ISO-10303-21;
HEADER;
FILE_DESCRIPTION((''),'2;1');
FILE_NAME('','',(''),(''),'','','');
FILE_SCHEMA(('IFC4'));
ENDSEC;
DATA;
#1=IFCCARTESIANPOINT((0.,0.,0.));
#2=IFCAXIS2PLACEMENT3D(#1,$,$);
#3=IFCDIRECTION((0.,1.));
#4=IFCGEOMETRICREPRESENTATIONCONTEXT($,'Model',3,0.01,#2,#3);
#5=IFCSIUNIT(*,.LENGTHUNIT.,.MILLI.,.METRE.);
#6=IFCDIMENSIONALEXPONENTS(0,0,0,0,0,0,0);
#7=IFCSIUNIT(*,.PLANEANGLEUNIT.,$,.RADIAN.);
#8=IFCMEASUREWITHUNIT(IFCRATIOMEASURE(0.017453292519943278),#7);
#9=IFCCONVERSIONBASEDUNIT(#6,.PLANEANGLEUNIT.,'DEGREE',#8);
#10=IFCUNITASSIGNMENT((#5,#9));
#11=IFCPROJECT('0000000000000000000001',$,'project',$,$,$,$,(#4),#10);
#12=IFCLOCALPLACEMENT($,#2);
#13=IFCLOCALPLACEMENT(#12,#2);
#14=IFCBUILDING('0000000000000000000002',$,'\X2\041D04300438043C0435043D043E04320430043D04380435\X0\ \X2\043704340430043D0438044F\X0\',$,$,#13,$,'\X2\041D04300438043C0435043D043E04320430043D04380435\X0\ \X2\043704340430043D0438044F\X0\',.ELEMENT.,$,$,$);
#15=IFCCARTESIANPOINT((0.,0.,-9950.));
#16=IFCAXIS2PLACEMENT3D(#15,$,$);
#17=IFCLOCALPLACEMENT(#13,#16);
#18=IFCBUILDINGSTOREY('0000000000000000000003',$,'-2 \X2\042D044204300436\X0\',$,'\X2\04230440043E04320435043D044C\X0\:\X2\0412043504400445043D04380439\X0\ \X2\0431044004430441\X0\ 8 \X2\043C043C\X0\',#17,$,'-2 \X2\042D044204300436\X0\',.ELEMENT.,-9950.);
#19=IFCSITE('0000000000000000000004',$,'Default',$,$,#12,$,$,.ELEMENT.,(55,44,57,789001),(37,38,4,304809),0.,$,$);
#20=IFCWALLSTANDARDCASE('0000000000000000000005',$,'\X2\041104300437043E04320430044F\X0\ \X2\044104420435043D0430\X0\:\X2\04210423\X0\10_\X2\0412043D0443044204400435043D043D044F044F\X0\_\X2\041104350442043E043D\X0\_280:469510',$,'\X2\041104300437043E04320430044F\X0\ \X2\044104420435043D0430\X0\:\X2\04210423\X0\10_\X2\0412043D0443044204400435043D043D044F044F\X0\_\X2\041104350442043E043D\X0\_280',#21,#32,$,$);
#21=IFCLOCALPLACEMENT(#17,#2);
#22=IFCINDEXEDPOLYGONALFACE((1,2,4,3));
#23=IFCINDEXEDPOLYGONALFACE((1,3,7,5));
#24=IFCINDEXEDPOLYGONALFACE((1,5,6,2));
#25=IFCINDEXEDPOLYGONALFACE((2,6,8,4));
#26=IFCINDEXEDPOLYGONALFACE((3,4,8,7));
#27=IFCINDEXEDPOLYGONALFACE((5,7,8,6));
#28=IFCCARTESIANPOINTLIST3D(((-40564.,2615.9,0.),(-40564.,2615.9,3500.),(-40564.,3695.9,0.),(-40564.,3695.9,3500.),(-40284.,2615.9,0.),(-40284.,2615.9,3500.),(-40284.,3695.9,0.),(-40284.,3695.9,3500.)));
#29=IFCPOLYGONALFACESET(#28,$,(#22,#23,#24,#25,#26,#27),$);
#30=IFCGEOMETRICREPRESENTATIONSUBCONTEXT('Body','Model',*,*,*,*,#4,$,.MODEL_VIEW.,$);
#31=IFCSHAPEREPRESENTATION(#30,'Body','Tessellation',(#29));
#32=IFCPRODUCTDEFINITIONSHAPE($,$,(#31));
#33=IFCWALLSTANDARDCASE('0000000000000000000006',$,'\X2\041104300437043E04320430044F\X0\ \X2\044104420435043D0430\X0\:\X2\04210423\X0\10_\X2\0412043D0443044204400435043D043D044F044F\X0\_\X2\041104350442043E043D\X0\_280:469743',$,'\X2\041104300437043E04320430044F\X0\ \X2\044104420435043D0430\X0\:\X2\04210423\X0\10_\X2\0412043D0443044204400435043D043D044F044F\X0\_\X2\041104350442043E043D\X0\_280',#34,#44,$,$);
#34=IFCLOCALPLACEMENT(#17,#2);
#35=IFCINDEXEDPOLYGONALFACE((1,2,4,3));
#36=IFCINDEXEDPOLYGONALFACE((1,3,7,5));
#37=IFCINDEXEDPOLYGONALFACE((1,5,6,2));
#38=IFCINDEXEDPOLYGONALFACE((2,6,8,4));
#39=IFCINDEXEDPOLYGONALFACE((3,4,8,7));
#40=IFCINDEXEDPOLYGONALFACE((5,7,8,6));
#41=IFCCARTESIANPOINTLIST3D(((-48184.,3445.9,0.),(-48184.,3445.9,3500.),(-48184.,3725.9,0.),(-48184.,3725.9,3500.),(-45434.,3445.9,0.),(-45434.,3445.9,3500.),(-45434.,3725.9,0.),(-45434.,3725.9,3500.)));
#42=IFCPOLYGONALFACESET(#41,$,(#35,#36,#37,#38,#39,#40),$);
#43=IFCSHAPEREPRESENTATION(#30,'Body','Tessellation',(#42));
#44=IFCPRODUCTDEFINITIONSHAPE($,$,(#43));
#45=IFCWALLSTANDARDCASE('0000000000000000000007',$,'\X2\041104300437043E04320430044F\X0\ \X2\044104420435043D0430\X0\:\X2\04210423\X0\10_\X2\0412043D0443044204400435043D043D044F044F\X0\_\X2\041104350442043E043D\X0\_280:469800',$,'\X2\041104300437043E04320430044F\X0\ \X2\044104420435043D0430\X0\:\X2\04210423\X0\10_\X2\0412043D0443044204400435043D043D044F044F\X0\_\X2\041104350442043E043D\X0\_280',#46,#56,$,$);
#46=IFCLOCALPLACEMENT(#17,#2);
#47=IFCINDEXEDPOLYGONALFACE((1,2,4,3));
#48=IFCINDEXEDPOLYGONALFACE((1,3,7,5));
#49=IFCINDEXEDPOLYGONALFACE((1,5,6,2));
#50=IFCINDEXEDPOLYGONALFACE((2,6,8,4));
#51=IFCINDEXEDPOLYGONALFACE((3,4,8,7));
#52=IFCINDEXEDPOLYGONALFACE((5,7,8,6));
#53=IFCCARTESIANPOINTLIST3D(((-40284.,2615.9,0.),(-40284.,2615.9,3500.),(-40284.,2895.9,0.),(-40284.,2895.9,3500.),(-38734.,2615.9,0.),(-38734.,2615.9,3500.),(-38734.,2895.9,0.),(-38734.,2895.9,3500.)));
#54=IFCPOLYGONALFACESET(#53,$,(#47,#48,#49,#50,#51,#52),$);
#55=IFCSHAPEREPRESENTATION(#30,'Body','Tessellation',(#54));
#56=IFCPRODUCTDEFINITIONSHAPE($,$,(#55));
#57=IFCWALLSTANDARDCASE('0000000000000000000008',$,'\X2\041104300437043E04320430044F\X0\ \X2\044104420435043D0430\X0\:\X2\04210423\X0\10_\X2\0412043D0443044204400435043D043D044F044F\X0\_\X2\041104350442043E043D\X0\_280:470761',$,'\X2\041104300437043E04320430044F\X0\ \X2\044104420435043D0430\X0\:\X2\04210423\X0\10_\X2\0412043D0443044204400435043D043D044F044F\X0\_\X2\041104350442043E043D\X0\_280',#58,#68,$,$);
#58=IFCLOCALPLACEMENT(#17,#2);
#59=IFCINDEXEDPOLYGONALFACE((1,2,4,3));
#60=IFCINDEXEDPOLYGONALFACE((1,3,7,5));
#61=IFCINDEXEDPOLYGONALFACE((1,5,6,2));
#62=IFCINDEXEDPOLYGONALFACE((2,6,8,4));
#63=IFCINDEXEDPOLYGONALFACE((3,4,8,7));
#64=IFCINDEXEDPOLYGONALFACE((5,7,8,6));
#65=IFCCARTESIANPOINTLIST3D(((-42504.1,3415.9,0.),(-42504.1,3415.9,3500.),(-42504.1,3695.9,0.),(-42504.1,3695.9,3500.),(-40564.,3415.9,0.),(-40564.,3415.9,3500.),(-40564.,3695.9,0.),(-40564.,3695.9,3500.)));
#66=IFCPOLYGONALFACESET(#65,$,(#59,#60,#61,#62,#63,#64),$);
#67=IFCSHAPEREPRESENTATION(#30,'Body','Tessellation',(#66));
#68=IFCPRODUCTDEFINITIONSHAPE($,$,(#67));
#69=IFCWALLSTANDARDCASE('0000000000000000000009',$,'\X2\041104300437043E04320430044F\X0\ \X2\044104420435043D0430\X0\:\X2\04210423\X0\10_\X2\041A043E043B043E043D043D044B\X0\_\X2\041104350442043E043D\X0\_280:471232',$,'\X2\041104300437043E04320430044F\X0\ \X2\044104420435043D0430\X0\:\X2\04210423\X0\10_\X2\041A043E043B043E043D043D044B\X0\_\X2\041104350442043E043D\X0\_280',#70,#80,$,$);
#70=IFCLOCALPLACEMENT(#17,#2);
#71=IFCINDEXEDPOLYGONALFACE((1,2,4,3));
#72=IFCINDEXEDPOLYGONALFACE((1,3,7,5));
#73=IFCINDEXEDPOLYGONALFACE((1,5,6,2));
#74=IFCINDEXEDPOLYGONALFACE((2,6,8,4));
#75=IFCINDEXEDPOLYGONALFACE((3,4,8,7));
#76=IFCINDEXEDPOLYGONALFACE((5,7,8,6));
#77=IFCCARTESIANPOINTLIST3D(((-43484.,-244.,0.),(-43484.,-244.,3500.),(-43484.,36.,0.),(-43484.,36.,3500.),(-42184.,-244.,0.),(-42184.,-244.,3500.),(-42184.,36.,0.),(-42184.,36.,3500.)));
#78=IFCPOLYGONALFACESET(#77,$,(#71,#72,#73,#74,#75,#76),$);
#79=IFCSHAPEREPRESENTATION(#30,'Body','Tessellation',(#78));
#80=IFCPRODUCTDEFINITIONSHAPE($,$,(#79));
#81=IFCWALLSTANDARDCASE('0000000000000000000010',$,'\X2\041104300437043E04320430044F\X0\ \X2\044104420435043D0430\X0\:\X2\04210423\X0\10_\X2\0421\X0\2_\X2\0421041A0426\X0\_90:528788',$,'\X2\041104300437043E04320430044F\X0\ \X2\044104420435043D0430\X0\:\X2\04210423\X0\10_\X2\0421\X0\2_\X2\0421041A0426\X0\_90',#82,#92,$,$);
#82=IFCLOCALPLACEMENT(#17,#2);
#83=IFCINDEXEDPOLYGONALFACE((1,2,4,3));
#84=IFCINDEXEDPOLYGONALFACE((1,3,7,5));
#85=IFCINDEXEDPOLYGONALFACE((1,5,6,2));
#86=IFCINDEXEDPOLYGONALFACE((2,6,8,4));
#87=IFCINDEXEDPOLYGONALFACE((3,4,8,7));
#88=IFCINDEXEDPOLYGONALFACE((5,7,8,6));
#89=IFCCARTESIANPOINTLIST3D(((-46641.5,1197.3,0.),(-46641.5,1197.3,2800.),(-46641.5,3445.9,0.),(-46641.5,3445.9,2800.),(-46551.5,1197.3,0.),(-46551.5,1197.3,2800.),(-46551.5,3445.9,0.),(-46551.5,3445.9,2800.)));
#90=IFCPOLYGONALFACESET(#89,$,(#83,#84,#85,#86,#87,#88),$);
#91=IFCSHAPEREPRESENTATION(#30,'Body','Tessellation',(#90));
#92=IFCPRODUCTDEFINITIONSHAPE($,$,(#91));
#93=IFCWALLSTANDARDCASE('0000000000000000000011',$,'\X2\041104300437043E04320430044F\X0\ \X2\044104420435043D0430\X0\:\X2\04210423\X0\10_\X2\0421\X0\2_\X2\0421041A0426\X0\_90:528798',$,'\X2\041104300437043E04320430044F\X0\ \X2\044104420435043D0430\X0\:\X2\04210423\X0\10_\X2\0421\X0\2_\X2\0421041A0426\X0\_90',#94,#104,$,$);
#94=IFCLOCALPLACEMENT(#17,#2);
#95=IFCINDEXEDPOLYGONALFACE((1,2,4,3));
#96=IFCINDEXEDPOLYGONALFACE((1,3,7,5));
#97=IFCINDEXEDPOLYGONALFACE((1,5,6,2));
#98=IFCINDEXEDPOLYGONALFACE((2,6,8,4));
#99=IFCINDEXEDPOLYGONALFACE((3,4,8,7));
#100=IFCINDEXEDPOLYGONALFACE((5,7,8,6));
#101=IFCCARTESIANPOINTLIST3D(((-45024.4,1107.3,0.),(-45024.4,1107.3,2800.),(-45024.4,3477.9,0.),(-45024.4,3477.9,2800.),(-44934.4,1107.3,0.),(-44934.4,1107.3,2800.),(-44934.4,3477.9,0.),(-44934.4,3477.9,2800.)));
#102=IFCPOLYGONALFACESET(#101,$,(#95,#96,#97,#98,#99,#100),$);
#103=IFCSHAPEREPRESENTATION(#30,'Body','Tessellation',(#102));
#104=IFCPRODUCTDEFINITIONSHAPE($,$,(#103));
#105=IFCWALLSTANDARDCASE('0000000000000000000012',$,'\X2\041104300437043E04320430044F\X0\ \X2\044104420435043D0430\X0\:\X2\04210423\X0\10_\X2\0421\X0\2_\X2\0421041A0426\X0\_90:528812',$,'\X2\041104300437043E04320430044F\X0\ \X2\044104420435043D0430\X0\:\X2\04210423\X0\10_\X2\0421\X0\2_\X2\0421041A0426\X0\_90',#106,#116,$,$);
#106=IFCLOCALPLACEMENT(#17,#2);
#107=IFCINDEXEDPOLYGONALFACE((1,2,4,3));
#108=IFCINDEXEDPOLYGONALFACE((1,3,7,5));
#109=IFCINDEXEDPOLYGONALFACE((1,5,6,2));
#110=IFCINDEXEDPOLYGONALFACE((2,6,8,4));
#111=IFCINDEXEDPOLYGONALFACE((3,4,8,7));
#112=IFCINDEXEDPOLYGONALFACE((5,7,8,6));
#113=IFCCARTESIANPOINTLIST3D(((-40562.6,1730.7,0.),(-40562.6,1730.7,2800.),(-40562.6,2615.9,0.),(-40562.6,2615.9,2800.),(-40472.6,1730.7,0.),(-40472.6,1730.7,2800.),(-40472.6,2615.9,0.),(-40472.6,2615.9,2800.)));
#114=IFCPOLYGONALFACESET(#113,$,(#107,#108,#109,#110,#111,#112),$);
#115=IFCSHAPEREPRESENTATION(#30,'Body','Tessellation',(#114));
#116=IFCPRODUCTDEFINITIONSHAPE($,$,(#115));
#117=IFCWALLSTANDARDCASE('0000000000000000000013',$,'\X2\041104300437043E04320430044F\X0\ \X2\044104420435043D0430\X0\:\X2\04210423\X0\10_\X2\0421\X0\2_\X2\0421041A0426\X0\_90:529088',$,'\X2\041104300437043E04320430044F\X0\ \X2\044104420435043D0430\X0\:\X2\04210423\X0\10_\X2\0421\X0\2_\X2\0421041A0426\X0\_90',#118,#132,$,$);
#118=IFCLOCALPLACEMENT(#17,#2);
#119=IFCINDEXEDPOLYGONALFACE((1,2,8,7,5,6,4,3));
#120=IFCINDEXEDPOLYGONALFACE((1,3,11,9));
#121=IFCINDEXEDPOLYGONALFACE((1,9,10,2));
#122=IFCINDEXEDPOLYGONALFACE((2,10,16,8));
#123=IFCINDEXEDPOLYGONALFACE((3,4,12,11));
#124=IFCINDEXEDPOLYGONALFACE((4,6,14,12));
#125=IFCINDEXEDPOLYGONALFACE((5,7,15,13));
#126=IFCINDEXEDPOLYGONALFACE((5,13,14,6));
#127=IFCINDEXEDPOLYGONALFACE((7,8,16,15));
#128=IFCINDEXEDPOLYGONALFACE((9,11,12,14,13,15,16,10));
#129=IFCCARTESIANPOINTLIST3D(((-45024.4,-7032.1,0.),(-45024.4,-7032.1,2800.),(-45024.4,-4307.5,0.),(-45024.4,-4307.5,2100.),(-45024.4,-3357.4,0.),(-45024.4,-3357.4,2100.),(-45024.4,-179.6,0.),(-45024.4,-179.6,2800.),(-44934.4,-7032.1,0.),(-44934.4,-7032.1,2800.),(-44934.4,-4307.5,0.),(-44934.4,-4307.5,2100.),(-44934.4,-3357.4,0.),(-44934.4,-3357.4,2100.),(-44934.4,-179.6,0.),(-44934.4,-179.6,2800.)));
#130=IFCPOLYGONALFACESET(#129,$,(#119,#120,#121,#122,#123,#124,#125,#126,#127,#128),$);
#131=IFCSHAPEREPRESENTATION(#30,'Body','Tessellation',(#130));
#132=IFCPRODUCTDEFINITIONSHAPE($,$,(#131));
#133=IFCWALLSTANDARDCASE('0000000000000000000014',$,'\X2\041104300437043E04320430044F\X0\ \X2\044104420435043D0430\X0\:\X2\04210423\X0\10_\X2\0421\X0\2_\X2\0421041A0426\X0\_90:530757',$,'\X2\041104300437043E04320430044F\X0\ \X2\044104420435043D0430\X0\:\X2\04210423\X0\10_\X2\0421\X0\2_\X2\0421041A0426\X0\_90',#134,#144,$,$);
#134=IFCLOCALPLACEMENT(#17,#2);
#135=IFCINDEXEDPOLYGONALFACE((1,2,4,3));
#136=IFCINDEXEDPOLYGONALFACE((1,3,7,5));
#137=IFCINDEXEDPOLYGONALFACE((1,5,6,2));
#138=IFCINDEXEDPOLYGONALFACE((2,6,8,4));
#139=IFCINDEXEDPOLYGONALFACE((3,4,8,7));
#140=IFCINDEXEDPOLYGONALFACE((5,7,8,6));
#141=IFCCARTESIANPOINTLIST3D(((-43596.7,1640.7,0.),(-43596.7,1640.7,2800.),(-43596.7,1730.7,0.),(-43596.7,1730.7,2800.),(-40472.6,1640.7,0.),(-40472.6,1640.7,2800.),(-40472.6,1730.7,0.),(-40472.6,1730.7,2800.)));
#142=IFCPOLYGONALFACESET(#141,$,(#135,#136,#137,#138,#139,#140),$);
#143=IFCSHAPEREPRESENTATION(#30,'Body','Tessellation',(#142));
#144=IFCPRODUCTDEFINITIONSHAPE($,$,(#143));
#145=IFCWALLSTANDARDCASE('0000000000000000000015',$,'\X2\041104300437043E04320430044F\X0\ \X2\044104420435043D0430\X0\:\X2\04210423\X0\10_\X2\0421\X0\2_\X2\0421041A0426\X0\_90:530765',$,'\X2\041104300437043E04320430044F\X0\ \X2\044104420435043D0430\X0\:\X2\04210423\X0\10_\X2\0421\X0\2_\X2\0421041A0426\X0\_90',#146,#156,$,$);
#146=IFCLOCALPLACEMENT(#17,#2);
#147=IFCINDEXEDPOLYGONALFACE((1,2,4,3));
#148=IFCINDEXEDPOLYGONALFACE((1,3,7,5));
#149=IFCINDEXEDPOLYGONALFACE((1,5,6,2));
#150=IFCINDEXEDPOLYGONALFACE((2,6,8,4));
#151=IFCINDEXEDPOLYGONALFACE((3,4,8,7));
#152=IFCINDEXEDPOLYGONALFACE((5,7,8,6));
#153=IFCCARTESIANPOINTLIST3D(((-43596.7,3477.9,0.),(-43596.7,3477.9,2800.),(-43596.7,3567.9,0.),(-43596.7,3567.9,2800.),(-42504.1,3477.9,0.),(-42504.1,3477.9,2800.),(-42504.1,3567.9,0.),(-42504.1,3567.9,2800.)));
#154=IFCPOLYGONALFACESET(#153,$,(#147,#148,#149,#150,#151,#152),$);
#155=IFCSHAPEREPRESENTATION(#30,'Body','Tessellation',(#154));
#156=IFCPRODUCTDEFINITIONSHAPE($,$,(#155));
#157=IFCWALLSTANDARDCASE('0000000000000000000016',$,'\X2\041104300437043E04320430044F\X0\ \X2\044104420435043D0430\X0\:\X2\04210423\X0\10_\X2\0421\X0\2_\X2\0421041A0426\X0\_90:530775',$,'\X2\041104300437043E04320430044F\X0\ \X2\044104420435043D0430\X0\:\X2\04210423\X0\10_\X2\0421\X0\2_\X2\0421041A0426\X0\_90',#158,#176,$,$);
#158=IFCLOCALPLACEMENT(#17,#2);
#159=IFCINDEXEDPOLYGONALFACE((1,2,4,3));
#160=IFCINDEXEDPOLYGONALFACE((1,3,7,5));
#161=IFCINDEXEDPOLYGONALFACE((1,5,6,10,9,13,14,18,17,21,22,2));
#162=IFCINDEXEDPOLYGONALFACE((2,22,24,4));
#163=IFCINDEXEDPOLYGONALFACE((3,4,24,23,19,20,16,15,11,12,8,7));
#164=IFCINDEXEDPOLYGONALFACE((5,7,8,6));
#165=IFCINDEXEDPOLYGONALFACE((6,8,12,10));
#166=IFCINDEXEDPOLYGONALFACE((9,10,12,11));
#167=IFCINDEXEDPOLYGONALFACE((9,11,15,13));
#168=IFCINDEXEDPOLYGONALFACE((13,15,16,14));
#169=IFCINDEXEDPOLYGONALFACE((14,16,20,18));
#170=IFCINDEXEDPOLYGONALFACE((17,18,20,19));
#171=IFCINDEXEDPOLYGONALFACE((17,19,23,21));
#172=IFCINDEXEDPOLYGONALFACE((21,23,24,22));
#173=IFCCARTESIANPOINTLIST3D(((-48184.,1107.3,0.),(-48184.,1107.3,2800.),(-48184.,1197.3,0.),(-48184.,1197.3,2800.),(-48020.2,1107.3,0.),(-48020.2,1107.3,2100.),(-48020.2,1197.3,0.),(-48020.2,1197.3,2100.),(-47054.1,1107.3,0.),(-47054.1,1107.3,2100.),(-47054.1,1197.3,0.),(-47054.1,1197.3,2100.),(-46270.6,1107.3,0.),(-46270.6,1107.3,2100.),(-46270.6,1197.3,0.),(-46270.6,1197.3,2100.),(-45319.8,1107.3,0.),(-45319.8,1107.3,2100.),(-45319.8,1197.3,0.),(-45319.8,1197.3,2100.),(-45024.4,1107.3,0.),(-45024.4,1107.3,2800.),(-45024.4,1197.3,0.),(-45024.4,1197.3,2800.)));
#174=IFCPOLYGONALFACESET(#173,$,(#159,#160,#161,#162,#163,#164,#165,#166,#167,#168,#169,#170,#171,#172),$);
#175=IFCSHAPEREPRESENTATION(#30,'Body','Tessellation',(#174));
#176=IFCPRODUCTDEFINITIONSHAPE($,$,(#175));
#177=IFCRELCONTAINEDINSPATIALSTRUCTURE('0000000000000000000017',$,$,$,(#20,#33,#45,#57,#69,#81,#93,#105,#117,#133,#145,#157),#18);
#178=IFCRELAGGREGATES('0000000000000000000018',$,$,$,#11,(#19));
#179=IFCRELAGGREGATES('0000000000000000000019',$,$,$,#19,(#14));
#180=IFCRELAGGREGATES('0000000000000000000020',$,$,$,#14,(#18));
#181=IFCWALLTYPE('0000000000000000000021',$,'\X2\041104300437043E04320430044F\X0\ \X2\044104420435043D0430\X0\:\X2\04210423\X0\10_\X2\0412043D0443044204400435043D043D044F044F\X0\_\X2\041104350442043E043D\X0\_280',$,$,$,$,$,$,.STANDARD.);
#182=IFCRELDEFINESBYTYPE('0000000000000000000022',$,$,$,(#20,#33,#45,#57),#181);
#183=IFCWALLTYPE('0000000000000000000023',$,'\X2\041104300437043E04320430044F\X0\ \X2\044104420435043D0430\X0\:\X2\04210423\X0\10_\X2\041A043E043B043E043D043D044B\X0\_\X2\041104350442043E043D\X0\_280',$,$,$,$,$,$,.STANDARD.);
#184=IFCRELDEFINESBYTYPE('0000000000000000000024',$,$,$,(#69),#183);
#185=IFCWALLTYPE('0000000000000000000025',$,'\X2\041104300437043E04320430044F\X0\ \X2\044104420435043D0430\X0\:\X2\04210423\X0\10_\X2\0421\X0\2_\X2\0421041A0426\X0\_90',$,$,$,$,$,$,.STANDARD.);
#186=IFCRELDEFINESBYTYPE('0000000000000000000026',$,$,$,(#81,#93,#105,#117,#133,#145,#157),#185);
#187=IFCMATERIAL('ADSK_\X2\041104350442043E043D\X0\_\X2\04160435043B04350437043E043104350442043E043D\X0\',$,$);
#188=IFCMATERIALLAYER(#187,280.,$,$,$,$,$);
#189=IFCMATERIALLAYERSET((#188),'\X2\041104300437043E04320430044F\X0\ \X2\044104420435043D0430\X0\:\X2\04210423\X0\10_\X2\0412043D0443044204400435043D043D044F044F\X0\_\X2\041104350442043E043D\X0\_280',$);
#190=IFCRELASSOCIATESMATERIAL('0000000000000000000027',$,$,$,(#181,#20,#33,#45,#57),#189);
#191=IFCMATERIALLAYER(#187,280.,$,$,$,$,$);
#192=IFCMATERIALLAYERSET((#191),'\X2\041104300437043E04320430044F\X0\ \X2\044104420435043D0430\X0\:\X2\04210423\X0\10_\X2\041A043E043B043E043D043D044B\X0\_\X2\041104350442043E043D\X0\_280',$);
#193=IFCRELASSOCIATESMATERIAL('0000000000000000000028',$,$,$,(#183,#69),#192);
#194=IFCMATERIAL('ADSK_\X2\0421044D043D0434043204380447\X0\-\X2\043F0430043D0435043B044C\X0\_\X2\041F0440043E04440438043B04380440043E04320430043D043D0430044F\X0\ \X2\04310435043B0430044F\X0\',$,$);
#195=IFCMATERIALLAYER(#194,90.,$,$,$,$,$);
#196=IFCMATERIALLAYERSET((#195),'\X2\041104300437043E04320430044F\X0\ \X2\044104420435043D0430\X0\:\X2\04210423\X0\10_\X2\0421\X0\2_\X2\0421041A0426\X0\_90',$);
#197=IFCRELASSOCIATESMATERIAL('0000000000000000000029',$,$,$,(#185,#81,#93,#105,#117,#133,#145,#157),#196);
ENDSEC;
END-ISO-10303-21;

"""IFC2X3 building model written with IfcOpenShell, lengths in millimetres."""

from ifc_helpers import new_model, entity, si_unit, converted_unit, direction, frame, frame_2d, origin, place, context, subcontext, project, spatial, rectangle, extrude, material, layer, layer_set, layer_usage, type_object, element, save


model = new_model("IFC2X3")

# Units and contexts
model_context = context("Model", 3, precision=0.01, world=origin(), true_north=direction((0.0, 1.0)))
body_context = subcontext(model_context, "Body", "Model", "MODEL_VIEW")
ifc_project = project(units=[si_unit("LENGTHUNIT", "METRE", prefix="MILLI"), converted_unit("PLANEANGLEUNIT", "DEGREE", entity("IfcRatioMeasure", 0.017453292519943278), si_unit("PLANEANGLEUNIT", "RADIAN"), dimensions=[0, 0, 0, 0, 0, 0, 0])], contexts=[model_context])

# Site, building, storey
site_placement = place(None, origin())
site = spatial("IfcSite", under=ifc_project, at=site_placement, Name="Default", CompositionType="ELEMENT", RefLatitude=(55, 44, 57, 789001), RefLongitude=(37, 38, 4, 304809), RefElevation=0.0)
building_placement = place(site_placement, origin())
building = spatial("IfcBuilding", under=site, at=building_placement, Name="Наименование здания", LongName="Наименование здания", CompositionType="ELEMENT")
storey_placement = place(building_placement, frame((0.0, 0.0, -9950.0)))
storey = spatial("IfcBuildingStorey", under=building, at=storey_placement, Name="-2 Этаж", ObjectType="Уровень:Верхний брус 8 мм", LongName="-2 Этаж", CompositionType="ELEMENT", Elevation=-9950.0)

# Walls
ifc_material_1 = material(Name="ADSK_Бетон_Железобетон")
ifc_layer_1 = layer(ifc_material_1, 280.0)
ifc_layer_set_1 = layer_set([ifc_layer_1], Name="Базовая стена:СУ10_Внутренняя_Бетон_280")
ifc_layer_usage_1 = layer_usage(ifc_layer_set_1, "AXIS2", "NEGATIVE", 140.0)
wall_type_1 = type_object("IfcWallType", Name="Базовая стена:СУ10_Внутренняя_Бетон_280", PredefinedType="STANDARD", material=ifc_layer_set_1)
wall_1_placement = place(storey_placement, frame((-40424.0, 3695.9, 0.0), z_axis=(0.0, 0.0, 1.0), x_axis=(0.0, -1.0, 0.0)))
element("IfcWallStandardCase", 1, at=wall_1_placement, inside=storey, type_object=wall_type_1, material=ifc_layer_usage_1, Name="Базовая стена:СУ10_Внутренняя_Бетон_280:469510", ObjectType="Базовая стена:СУ10_Внутренняя_Бетон_280", context=body_context, shape_type="SweptSolid", body=[
    extrude(rectangle(XDim=1080.0, YDim=280.0, at=frame_2d((540.0, 0.0), x_axis=(-1.0, 0.0))), origin(), (0.0, 0.0, 1.0), 3500.0),
])
wall_2_placement = place(storey_placement, frame((-45434.0, 3585.9, 0.0), z_axis=(0.0, 0.0, 1.0), x_axis=(-1.0, 0.0, 0.0)))
element("IfcWallStandardCase", 2, at=wall_2_placement, inside=storey, type_object=wall_type_1, material=ifc_layer_usage_1, Name="Базовая стена:СУ10_Внутренняя_Бетон_280:469743", ObjectType="Базовая стена:СУ10_Внутренняя_Бетон_280", context=body_context, shape_type="SweptSolid", body=[
    extrude(rectangle(XDim=2750.0, YDim=280.0, at=frame_2d((1375.0, 0.0), x_axis=(-1.0, 0.0))), origin(), (0.0, 0.0, 1.0), 3500.0),
])
wall_3_placement = place(storey_placement, frame((-38734.0, 2755.9, 0.0), z_axis=(0.0, 0.0, 1.0), x_axis=(-1.0, 0.0, 0.0)))
element("IfcWallStandardCase", 3, at=wall_3_placement, inside=storey, type_object=wall_type_1, material=ifc_layer_usage_1, Name="Базовая стена:СУ10_Внутренняя_Бетон_280:469800", ObjectType="Базовая стена:СУ10_Внутренняя_Бетон_280", context=body_context, shape_type="SweptSolid", body=[
    extrude(rectangle(XDim=1550.0, YDim=280.0, at=frame_2d((775.0, 0.0), x_axis=(-1.0, 0.0))), origin(), (0.0, 0.0, 1.0), 3500.0),
])
wall_4_placement = place(storey_placement, frame((-40564.0, 3555.9, 0.0), z_axis=(0.0, 0.0, 1.0), x_axis=(-1.0, 0.0, 0.0)))
element("IfcWallStandardCase", 4, at=wall_4_placement, inside=storey, type_object=wall_type_1, material=ifc_layer_usage_1, Name="Базовая стена:СУ10_Внутренняя_Бетон_280:470761", ObjectType="Базовая стена:СУ10_Внутренняя_Бетон_280", context=body_context, shape_type="SweptSolid", body=[
    extrude(rectangle(XDim=1940.0, YDim=280.0, at=frame_2d((970.0, 0.0), x_axis=(-1.0, 0.0))), origin(), (0.0, 0.0, 1.0), 3500.0),
])
ifc_layer_2 = layer(ifc_material_1, 280.0)
ifc_layer_set_2 = layer_set([ifc_layer_2], Name="Базовая стена:СУ10_Колонны_Бетон_280")
ifc_layer_usage_2 = layer_usage(ifc_layer_set_2, "AXIS2", "NEGATIVE", 140.0)
wall_type_2 = type_object("IfcWallType", Name="Базовая стена:СУ10_Колонны_Бетон_280", PredefinedType="STANDARD", material=ifc_layer_set_2)
wall_5_placement = place(storey_placement, frame((-42184.0, -104.0, 0.0), z_axis=(0.0, 0.0, 1.0), x_axis=(-1.0, 0.0, 0.0)))
element("IfcWallStandardCase", 5, at=wall_5_placement, inside=storey, type_object=wall_type_2, material=ifc_layer_usage_2, Name="Базовая стена:СУ10_Колонны_Бетон_280:471232", ObjectType="Базовая стена:СУ10_Колонны_Бетон_280", context=body_context, shape_type="SweptSolid", body=[
    extrude(rectangle(XDim=1300.0, YDim=280.0, at=frame_2d((650.0, 0.0), x_axis=(-1.0, 0.0))), origin(), (0.0, 0.0, 1.0), 3500.0),
])
ifc_material_2 = material(Name="ADSK_Сэндвич-панель_Профилированная белая")
ifc_layer_3 = layer(ifc_material_2, 90.0)
ifc_layer_set_3 = layer_set([ifc_layer_3], Name="Базовая стена:СУ10_С2_СКЦ_90")
ifc_layer_usage_3 = layer_usage(ifc_layer_set_3, "AXIS2", "NEGATIVE", 45.0)
wall_type_3 = type_object("IfcWallType", Name="Базовая стена:СУ10_С2_СКЦ_90", PredefinedType="STANDARD", material=ifc_layer_set_3)
wall_6_placement = place(storey_placement, frame((-46596.5, 3445.9, 0.0), z_axis=(0.0, 0.0, 1.0), x_axis=(0.0, -1.0, 0.0)))
element("IfcWallStandardCase", 6, at=wall_6_placement, inside=storey, type_object=wall_type_3, material=ifc_layer_usage_3, Name="Базовая стена:СУ10_С2_СКЦ_90:528788", ObjectType="Базовая стена:СУ10_С2_СКЦ_90", context=body_context, shape_type="SweptSolid", body=[
    extrude(rectangle(XDim=2248.6, YDim=90.0, at=frame_2d((1124.3, 0.0), x_axis=(-1.0, 0.0))), origin(), (0.0, 0.0, 1.0), 2800.0),
])
wall_7_placement = place(storey_placement, frame((-44979.4, 3477.9, 0.0), z_axis=(0.0, 0.0, 1.0), x_axis=(0.0, -1.0, 0.0)))
element("IfcWallStandardCase", 7, at=wall_7_placement, inside=storey, type_object=wall_type_3, material=ifc_layer_usage_3, Name="Базовая стена:СУ10_С2_СКЦ_90:528798", ObjectType="Базовая стена:СУ10_С2_СКЦ_90", context=body_context, shape_type="SweptSolid", body=[
    extrude(rectangle(XDim=2370.6, YDim=90.0, at=frame_2d((1185.3, 0.0), x_axis=(-1.0, 0.0))), origin(), (0.0, 0.0, 1.0), 2800.0),
])
wall_8_placement = place(storey_placement, frame((-40517.6, 2615.9, 0.0), z_axis=(0.0, 0.0, 1.0), x_axis=(0.0, -1.0, 0.0)))
element("IfcWallStandardCase", 8, at=wall_8_placement, inside=storey, type_object=wall_type_3, material=ifc_layer_usage_3, Name="Базовая стена:СУ10_С2_СКЦ_90:528812", ObjectType="Базовая стена:СУ10_С2_СКЦ_90", context=body_context, shape_type="SweptSolid", body=[
    extrude(rectangle(XDim=885.2, YDim=90.0, at=frame_2d((442.6, 0.0), x_axis=(-1.0, 0.0))), origin(), (0.0, 0.0, 1.0), 2800.0),
])

# Wall, opening
wall_9_placement = place(storey_placement, frame((-44979.4, -179.6, 0.0), z_axis=(0.0, 0.0, 1.0), x_axis=(0.0, -1.0, 0.0)))
wall_9 = element("IfcWallStandardCase", 9, at=wall_9_placement, inside=storey, type_object=wall_type_3, material=ifc_layer_usage_3, Name="Базовая стена:СУ10_С2_СКЦ_90:529088", ObjectType="Базовая стена:СУ10_С2_СКЦ_90", context=body_context, shape_type="SweptSolid", body=[
    extrude(rectangle(XDim=6852.5, YDim=90.0, at=frame_2d((3426.2, 0.0), x_axis=(-1.0, 0.0))), origin(), (0.0, 0.0, 1.0), 2800.0),
])
opening_1_placement = place(wall_9_placement, origin())
element("IfcOpeningElement", 10, at=opening_1_placement, cuts=wall_9, ObjectType="Opening", context=body_context, shape_type="SweptSolid", body=[
    extrude(rectangle(XDim=2100.0, YDim=950.2, at=frame_2d((0.0, 0.0), x_axis=(1.0, 0.0))), frame((3652.9, -45.0, 1050.0), z_axis=(0.0, 1.0, 0.0), x_axis=(0.0, 0.0, -1.0)), (0.0, 0.0, 1.0), 90.0),
])

# Walls
wall_10_placement = place(storey_placement, frame((-40472.6, 1685.7, 0.0), z_axis=(0.0, 0.0, 1.0), x_axis=(-1.0, 0.0, 0.0)))
element("IfcWallStandardCase", 11, at=wall_10_placement, inside=storey, type_object=wall_type_3, material=ifc_layer_usage_3, Name="Базовая стена:СУ10_С2_СКЦ_90:530757", ObjectType="Базовая стена:СУ10_С2_СКЦ_90", context=body_context, shape_type="SweptSolid", body=[
    extrude(rectangle(XDim=3124.1, YDim=90.0, at=frame_2d((1562.1, 0.0), x_axis=(-1.0, 0.0))), origin(), (0.0, 0.0, 1.0), 2800.0),
])
wall_11_placement = place(storey_placement, frame((-42504.1, 3522.9, 0.0), z_axis=(0.0, 0.0, 1.0), x_axis=(-1.0, 0.0, 0.0)))
element("IfcWallStandardCase", 12, at=wall_11_placement, inside=storey, type_object=wall_type_3, material=ifc_layer_usage_3, Name="Базовая стена:СУ10_С2_СКЦ_90:530765", ObjectType="Базовая стена:СУ10_С2_СКЦ_90", context=body_context, shape_type="SweptSolid", body=[
    extrude(rectangle(XDim=1092.6, YDim=90.0, at=frame_2d((546.3, 0.0), x_axis=(-1.0, 0.0))), origin(), (0.0, 0.0, 1.0), 2800.0),
])

# Wall, openings
wall_12_placement = place(storey_placement, frame((-45024.4, 1152.3, 0.0), z_axis=(0.0, 0.0, 1.0), x_axis=(-1.0, 0.0, 0.0)))
wall_12 = element("IfcWallStandardCase", 13, at=wall_12_placement, inside=storey, type_object=wall_type_3, material=ifc_layer_usage_3, Name="Базовая стена:СУ10_С2_СКЦ_90:530775", ObjectType="Базовая стена:СУ10_С2_СКЦ_90", context=body_context, shape_type="SweptSolid", body=[
    extrude(rectangle(XDim=3159.6, YDim=90.0, at=frame_2d((1579.8, 0.0), x_axis=(-1.0, 0.0))), origin(), (0.0, 0.0, 1.0), 2800.0),
])
opening_2_placement = place(wall_12_placement, origin())
element("IfcOpeningElement", 14, at=opening_2_placement, cuts=wall_12, ObjectType="Opening", context=body_context, shape_type="SweptSolid", body=[
    extrude(rectangle(XDim=2100.0, YDim=950.7, at=frame_2d((0.0, 0.0), x_axis=(1.0, 0.0))), frame((770.8, -45.0, 1050.0), z_axis=(0.0, 1.0, 0.0), x_axis=(0.0, 0.0, -1.0)), (0.0, 0.0, 1.0), 90.0),
])
opening_3_placement = place(wall_12_placement, origin())
element("IfcOpeningElement", 15, at=opening_3_placement, cuts=wall_12, ObjectType="Opening", context=body_context, shape_type="SweptSolid", body=[
    extrude(rectangle(XDim=2100.0, YDim=966.1, at=frame_2d((0.0, 0.0), x_axis=(1.0, 0.0))), frame((2512.7, -45.0, 1050.0), z_axis=(0.0, 1.0, 0.0), x_axis=(0.0, 0.0, -1.0)), (0.0, 0.0, 1.0), 90.0),
])

save(model, "model.ifc")
